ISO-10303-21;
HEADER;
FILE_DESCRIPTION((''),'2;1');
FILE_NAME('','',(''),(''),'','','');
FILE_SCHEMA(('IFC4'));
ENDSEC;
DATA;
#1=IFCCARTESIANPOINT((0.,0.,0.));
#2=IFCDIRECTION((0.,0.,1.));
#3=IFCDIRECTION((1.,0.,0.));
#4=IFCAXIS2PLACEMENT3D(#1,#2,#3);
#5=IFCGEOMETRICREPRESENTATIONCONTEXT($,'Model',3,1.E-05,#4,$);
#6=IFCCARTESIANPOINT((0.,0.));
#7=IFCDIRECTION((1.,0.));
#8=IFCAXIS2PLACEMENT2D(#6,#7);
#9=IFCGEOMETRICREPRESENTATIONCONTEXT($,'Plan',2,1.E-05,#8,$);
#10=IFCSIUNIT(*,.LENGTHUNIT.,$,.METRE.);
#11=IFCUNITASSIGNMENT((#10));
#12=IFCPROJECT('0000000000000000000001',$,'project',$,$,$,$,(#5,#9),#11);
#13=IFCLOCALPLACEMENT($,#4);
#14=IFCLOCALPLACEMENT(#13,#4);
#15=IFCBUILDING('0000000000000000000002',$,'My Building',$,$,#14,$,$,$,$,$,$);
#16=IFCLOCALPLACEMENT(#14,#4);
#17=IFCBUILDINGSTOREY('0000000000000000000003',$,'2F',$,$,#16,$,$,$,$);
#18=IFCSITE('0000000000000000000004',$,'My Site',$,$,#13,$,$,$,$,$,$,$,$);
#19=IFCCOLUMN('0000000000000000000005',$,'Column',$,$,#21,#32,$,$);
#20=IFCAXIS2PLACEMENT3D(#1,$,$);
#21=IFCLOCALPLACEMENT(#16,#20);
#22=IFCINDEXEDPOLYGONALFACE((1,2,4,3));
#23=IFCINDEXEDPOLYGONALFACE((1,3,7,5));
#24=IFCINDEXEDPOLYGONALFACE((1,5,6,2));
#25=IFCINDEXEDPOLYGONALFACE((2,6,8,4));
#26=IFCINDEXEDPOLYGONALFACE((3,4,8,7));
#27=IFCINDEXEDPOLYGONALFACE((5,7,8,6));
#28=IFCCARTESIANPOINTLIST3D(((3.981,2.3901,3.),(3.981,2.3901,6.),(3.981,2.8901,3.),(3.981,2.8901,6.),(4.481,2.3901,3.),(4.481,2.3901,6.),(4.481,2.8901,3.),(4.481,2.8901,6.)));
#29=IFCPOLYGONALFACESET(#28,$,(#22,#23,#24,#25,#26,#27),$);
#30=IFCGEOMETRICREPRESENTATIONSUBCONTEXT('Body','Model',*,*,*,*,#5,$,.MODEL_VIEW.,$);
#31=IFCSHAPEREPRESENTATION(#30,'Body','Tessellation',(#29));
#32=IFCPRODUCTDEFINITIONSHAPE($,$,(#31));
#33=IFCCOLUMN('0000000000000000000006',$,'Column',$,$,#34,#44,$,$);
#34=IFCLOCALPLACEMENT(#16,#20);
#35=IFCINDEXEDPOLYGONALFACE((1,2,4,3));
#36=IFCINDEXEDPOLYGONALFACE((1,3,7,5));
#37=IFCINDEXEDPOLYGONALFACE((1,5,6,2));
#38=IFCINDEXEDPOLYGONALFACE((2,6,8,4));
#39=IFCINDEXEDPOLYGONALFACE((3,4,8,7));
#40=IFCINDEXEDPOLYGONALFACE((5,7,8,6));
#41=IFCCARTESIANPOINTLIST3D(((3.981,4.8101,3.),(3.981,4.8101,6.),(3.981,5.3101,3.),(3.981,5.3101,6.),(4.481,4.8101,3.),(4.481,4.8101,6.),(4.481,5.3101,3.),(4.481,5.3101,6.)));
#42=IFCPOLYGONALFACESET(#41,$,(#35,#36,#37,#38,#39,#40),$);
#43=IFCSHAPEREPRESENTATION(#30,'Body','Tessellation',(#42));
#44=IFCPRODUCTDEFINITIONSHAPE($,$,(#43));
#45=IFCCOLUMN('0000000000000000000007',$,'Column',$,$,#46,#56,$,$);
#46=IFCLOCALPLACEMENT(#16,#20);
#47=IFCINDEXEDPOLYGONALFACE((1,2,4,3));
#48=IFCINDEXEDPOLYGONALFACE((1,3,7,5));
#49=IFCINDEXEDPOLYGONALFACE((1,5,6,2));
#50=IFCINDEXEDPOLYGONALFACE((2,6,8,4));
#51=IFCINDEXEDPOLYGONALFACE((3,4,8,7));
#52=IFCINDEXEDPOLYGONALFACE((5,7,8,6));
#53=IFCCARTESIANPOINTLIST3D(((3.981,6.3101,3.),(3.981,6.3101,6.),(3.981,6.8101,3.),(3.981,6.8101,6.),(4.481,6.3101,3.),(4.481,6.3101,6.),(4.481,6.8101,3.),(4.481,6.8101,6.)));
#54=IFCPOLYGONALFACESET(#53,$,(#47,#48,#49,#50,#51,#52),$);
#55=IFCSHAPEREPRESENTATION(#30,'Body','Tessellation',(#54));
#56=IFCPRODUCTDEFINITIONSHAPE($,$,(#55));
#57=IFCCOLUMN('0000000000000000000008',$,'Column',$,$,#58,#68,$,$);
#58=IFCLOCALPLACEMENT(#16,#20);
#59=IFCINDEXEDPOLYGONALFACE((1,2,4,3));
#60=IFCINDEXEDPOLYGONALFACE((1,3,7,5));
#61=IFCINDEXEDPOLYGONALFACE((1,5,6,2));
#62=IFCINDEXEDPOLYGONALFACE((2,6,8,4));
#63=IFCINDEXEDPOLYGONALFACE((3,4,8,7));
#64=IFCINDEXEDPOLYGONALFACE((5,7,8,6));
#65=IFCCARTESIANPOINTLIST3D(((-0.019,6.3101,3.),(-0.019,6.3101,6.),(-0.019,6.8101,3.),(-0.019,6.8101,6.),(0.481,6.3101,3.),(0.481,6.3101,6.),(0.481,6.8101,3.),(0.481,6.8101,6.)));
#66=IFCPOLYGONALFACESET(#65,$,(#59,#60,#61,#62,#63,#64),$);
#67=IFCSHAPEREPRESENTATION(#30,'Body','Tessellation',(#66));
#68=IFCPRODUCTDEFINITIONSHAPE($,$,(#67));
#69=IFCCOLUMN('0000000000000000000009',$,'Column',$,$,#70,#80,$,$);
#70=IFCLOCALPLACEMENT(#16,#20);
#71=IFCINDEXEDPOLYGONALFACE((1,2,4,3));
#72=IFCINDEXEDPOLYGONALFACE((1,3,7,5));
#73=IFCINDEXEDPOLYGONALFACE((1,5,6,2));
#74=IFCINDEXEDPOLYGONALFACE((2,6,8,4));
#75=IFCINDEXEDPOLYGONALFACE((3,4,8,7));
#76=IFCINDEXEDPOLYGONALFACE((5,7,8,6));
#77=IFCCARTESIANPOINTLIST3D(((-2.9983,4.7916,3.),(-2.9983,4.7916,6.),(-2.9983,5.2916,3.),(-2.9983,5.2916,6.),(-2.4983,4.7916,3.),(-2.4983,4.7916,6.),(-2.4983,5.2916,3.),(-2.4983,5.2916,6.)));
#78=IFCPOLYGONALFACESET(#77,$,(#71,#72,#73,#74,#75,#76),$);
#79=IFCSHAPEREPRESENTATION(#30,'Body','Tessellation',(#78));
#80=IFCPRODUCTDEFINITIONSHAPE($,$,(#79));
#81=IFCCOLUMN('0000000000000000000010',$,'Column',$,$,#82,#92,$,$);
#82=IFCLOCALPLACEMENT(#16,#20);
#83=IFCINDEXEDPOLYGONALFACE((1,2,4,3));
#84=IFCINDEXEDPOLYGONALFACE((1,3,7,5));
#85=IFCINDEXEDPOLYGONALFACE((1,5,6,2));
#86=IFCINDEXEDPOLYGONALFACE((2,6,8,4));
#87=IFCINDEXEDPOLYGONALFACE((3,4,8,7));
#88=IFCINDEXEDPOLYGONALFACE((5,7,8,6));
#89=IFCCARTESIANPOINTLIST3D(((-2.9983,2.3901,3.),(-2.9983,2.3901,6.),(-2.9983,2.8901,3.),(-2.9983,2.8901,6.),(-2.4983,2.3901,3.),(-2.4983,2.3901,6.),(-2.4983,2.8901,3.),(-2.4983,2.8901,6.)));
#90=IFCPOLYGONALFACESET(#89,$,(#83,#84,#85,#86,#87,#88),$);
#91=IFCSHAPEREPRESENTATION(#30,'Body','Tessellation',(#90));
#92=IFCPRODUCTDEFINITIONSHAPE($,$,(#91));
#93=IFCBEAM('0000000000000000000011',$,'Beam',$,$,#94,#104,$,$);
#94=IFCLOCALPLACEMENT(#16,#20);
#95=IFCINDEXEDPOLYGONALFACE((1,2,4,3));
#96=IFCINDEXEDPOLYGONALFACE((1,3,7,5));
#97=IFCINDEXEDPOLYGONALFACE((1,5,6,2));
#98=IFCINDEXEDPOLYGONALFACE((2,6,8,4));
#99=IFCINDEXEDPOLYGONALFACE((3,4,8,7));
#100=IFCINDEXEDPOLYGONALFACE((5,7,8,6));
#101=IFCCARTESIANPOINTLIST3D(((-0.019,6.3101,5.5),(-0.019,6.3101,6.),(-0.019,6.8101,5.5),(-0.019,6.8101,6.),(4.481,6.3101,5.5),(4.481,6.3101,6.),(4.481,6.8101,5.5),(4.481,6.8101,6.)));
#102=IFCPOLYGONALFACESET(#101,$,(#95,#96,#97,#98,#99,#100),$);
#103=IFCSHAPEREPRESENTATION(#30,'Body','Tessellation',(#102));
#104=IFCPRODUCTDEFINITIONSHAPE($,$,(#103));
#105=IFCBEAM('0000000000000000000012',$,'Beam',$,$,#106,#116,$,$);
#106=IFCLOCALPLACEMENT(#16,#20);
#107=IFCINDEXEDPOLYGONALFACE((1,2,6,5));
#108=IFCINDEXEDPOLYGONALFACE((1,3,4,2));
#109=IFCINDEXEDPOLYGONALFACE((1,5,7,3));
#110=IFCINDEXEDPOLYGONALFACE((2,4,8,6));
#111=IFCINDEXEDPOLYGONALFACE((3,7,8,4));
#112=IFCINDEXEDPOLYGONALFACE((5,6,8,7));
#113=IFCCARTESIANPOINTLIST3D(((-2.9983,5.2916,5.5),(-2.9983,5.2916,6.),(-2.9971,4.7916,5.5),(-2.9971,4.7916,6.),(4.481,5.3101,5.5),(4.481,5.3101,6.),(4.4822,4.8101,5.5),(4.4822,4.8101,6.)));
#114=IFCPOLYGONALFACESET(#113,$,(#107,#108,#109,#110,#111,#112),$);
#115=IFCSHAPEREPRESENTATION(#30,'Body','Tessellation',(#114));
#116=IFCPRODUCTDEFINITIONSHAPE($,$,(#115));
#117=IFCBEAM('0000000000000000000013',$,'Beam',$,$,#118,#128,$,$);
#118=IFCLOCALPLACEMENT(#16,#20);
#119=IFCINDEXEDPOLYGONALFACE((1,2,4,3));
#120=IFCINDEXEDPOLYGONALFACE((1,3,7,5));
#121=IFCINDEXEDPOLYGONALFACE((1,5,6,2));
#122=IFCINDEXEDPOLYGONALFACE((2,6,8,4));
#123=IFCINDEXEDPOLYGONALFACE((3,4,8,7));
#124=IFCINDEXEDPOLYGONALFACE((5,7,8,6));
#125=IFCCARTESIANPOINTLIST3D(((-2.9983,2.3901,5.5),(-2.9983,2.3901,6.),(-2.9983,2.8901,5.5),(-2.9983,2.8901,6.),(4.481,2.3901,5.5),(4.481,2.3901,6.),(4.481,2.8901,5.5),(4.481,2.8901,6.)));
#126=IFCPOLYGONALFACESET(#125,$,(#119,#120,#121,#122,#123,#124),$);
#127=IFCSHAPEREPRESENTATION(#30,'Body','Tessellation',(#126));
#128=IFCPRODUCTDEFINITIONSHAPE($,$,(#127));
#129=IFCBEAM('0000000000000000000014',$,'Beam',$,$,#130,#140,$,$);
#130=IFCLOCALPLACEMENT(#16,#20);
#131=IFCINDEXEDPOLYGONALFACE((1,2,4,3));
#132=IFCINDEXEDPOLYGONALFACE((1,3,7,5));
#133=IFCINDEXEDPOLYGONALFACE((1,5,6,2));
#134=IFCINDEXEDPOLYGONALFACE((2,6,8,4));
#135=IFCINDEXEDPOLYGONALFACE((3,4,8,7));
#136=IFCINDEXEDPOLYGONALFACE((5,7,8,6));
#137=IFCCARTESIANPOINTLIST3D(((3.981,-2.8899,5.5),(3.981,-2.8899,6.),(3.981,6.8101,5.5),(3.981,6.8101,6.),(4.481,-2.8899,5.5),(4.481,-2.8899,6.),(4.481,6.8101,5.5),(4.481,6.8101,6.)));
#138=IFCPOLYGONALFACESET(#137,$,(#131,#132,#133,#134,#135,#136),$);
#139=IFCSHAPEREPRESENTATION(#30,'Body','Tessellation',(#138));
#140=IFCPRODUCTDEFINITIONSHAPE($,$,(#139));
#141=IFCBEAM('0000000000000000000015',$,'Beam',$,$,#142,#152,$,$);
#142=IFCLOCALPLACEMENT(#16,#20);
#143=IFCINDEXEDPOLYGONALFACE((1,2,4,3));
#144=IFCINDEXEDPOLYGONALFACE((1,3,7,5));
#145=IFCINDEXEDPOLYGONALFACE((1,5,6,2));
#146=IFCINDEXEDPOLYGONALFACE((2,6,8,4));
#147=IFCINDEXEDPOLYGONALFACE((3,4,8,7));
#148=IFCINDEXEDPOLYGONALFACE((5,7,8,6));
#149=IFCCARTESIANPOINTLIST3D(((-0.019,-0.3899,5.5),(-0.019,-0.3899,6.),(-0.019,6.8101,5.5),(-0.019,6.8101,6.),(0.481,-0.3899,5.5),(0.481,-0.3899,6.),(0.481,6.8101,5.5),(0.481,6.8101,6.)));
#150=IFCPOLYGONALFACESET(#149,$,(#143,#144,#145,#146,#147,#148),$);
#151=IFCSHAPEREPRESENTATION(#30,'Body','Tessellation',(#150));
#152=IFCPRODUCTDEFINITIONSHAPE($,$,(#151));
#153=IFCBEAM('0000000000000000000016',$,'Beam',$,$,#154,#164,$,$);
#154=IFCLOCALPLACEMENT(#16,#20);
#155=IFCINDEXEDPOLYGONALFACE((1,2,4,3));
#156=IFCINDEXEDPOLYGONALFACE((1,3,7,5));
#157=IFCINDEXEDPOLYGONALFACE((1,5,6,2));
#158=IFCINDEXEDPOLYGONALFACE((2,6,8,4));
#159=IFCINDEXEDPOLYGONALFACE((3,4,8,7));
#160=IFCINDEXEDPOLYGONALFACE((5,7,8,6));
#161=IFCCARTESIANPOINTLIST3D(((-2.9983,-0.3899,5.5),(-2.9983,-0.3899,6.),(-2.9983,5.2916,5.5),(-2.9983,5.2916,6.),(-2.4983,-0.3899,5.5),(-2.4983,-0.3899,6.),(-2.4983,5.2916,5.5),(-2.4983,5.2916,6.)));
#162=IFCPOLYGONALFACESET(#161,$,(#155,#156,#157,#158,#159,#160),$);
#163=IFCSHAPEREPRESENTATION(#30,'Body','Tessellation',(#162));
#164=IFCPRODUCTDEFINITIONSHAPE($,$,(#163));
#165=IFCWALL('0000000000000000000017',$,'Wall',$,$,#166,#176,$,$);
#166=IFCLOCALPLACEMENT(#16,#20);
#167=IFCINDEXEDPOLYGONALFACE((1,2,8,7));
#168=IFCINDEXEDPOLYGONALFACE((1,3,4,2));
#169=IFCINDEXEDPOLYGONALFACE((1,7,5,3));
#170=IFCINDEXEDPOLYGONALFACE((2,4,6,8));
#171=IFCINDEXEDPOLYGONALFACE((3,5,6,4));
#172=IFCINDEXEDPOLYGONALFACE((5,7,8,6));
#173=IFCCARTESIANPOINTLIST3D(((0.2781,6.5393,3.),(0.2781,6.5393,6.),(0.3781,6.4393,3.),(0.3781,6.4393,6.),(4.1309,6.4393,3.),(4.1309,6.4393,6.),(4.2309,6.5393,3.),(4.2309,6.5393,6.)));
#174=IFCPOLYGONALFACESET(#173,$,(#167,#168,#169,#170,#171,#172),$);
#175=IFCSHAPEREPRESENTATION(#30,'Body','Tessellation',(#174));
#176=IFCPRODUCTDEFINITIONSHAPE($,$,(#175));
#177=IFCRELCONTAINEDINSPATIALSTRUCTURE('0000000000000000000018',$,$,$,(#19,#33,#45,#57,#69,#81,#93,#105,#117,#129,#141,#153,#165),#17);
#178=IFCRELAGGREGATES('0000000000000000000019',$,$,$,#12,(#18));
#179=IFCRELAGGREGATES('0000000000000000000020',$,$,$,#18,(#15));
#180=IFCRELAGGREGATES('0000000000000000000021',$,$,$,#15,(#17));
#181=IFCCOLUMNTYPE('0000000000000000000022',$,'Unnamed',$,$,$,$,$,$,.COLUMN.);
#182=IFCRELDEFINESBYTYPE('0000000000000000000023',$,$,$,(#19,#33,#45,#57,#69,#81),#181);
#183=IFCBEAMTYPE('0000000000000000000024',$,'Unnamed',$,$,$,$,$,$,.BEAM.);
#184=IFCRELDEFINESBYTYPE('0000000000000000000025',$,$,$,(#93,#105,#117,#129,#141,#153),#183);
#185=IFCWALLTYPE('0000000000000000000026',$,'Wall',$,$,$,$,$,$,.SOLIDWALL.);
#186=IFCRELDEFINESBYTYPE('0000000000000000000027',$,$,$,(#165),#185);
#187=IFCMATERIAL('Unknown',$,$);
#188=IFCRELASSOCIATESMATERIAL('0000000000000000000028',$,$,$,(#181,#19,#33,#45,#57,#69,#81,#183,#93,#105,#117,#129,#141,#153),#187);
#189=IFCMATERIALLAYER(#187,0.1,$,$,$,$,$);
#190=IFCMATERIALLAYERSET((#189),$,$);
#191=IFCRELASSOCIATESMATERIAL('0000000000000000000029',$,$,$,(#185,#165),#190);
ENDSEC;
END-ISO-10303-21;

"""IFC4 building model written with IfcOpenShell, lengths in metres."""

from ifc_helpers import new_model, si_unit, frame, origin_with_axes, origin_2d_with_axis, place, context, subcontext, project, spatial, line, indexed_curve, rectangle, outline, extrude, material, layer, layer_set, layer_usage, material_profile, profile_set, profile_usage, type_object, element, save


model = new_model("IFC4")

# Units and contexts
model_context = context("Model", 3, precision=1e-05, world=origin_with_axes())
plan_context = context("Plan", 2, precision=1e-05, world=origin_2d_with_axis())
body_context_1 = subcontext(model_context, "Body", "Model", "MODEL_VIEW")
ifc_project = project(units=[si_unit("LENGTHUNIT", "METRE")], contexts=[model_context, plan_context])

# Site, building, storey
site_placement = place(None, origin_with_axes())
site = spatial("IfcSite", under=ifc_project, at=site_placement, Name="My Site")
building_placement = place(site_placement, origin_with_axes())
building = spatial("IfcBuilding", under=site, at=building_placement, Name="My Building")
storey_placement = place(building_placement, origin_with_axes())
storey = spatial("IfcBuildingStorey", under=building, at=storey_placement, Name="2F")

# Columns
ifc_material = material(Name="Unknown")
ifc_material_profile_1 = material_profile(ifc_material, rectangle(XDim=0.5, YDim=0.5))
ifc_profile_set_1 = profile_set([ifc_material_profile_1])
ifc_profile_usage_1 = profile_usage(ifc_profile_set_1, cardinal=7)
column_type = type_object("IfcColumnType", Name="Unnamed", PredefinedType="COLUMN", material=ifc_profile_set_1)
column_1_placement = place(storey_placement, frame((4.481, 2.8901, 3.0), z_axis=(0.0, 0.0, 1.0), x_axis=(1.0, 0.0, 0.0)))
element("IfcColumn", 1, at=column_1_placement, inside=storey, type_object=column_type, material=ifc_profile_usage_1, Name="Column", context=body_context_1, shape_type="SweptSolid", body=[
    extrude(rectangle(XDim=0.5, YDim=0.5), frame((-0.25, -0.25, 0.0), z_axis=(0.0, 0.0, 1.0), x_axis=(1.0, 0.0, 0.0)), (0.0, 0.0, 1.0), 3.0),
])
ifc_profile_usage_2 = profile_usage(ifc_profile_set_1, cardinal=7)
column_2_placement = place(storey_placement, frame((4.481, 5.3101, 3.0), z_axis=(0.0, 0.0, 1.0), x_axis=(1.0, 0.0, 0.0)))
element("IfcColumn", 2, at=column_2_placement, inside=storey, type_object=column_type, material=ifc_profile_usage_2, Name="Column", context=body_context_1, shape_type="SweptSolid", body=[
    extrude(rectangle(XDim=0.5, YDim=0.5), frame((-0.25, -0.25, 0.0), z_axis=(0.0, 0.0, 1.0), x_axis=(1.0, 0.0, 0.0)), (0.0, 0.0, 1.0), 3.0),
])
ifc_profile_usage_3 = profile_usage(ifc_profile_set_1, cardinal=7)
column_3_placement = place(storey_placement, frame((4.481, 6.8101, 3.0), z_axis=(0.0, 0.0, 1.0), x_axis=(1.0, 0.0, 0.0)))
element("IfcColumn", 3, at=column_3_placement, inside=storey, type_object=column_type, material=ifc_profile_usage_3, Name="Column", context=body_context_1, shape_type="SweptSolid", body=[
    extrude(rectangle(XDim=0.5, YDim=0.5), frame((-0.25, -0.25, 0.0), z_axis=(0.0, 0.0, 1.0), x_axis=(1.0, 0.0, 0.0)), (0.0, 0.0, 1.0), 3.0),
])
ifc_profile_usage_4 = profile_usage(ifc_profile_set_1, cardinal=7)
column_4_placement = place(storey_placement, frame((0.481, 6.8101, 3.0), z_axis=(0.0, 0.0, 1.0), x_axis=(1.0, 0.0, 0.0)))
element("IfcColumn", 4, at=column_4_placement, inside=storey, type_object=column_type, material=ifc_profile_usage_4, Name="Column", context=body_context_1, shape_type="SweptSolid", body=[
    extrude(rectangle(XDim=0.5, YDim=0.5), frame((-0.25, -0.25, 0.0), z_axis=(0.0, 0.0, 1.0), x_axis=(1.0, 0.0, 0.0)), (0.0, 0.0, 1.0), 3.0),
])
ifc_profile_usage_5 = profile_usage(ifc_profile_set_1, cardinal=7)
column_5_placement = place(storey_placement, frame((-2.4983, 5.2916, 3.0), z_axis=(0.0, 0.0, 1.0), x_axis=(1.0, 0.0, 0.0)))
element("IfcColumn", 5, at=column_5_placement, inside=storey, type_object=column_type, material=ifc_profile_usage_5, Name="Column", context=body_context_1, shape_type="SweptSolid", body=[
    extrude(rectangle(XDim=0.5, YDim=0.5), frame((-0.25, -0.25, 0.0), z_axis=(0.0, 0.0, 1.0), x_axis=(1.0, 0.0, 0.0)), (0.0, 0.0, 1.0), 3.0),
])
ifc_profile_usage_6 = profile_usage(ifc_profile_set_1, cardinal=7)
column_6_placement = place(storey_placement, frame((-2.4983, 2.8901, 3.0), z_axis=(0.0, 0.0, 1.0), x_axis=(1.0, 0.0, 0.0)))
element("IfcColumn", 6, at=column_6_placement, inside=storey, type_object=column_type, material=ifc_profile_usage_6, Name="Column", context=body_context_1, shape_type="SweptSolid", body=[
    extrude(rectangle(XDim=0.5, YDim=0.5), frame((-0.25, -0.25, 0.0), z_axis=(0.0, 0.0, 1.0), x_axis=(1.0, 0.0, 0.0)), (0.0, 0.0, 1.0), 3.0),
])

# Beams
ifc_material_profile_2 = material_profile(ifc_material, rectangle(XDim=0.5, YDim=0.5))
ifc_profile_set_2 = profile_set([ifc_material_profile_2])
ifc_profile_usage_7 = profile_usage(ifc_profile_set_2, cardinal=7)
beam_type = type_object("IfcBeamType", Name="Unnamed", PredefinedType="BEAM", material=ifc_profile_set_2)
beam_1_placement = place(storey_placement, frame((-0.019, 6.8101, 6.0), z_axis=(1.0, -0.000001, 0.000001), x_axis=(0.000001, 1.0, 0.0)))
element("IfcBeam", 7, at=beam_1_placement, inside=storey, type_object=beam_type, material=ifc_profile_usage_7, Name="Beam", context=body_context_1, shape_type="SweptSolid", body=[
    extrude(rectangle(XDim=0.5, YDim=0.5), frame((-0.25, -0.25, 0.0), z_axis=(0.0, 0.0, 1.0), x_axis=(1.0, 0.0, 0.0)), (0.0, 0.0, 1.0), 4.5),
])
ifc_profile_usage_8 = profile_usage(ifc_profile_set_2, cardinal=7)
beam_2_placement = place(storey_placement, frame((-2.9983, 5.2916, 6.0), z_axis=(0.999997, 0.002473, 0.0), x_axis=(-0.002473, 0.999997, 0.0)))
element("IfcBeam", 8, at=beam_2_placement, inside=storey, type_object=beam_type, material=ifc_profile_usage_8, Name="Beam", context=body_context_1, shape_type="SweptSolid", body=[
    extrude(rectangle(XDim=0.5, YDim=0.5), frame((-0.25, -0.25, 0.0), z_axis=(0.0, 0.0, 1.0), x_axis=(1.0, 0.0, 0.0)), (0.0, 0.0, 1.0), 7.4793),
])
ifc_profile_usage_9 = profile_usage(ifc_profile_set_2, cardinal=7)
beam_3_placement = place(storey_placement, frame((-2.9983, 2.8901, 6.0), z_axis=(1.0, 0.0, 0.0), x_axis=(0.0, 1.0, 0.0)))
element("IfcBeam", 9, at=beam_3_placement, inside=storey, type_object=beam_type, material=ifc_profile_usage_9, Name="Beam", context=body_context_1, shape_type="SweptSolid", body=[
    extrude(rectangle(XDim=0.5, YDim=0.5), frame((-0.25, -0.25, 0.0), z_axis=(0.0, 0.0, 1.0), x_axis=(1.0, 0.0, 0.0)), (0.0, 0.0, 1.0), 7.4793),
])
ifc_profile_usage_10 = profile_usage(ifc_profile_set_2, cardinal=7)
beam_4_placement = place(storey_placement, frame((4.481, 6.8101, 6.0), z_axis=(0.0, -1.0, 0.0), x_axis=(1.0, 0.0, 0.0)))
element("IfcBeam", 10, at=beam_4_placement, inside=storey, type_object=beam_type, material=ifc_profile_usage_10, Name="Beam", context=body_context_1, shape_type="SweptSolid", body=[
    extrude(rectangle(XDim=0.5, YDim=0.5), frame((-0.25, -0.25, 0.0), z_axis=(0.0, 0.0, 1.0), x_axis=(1.0, 0.0, 0.0)), (0.0, 0.0, 1.0), 9.7),
])
ifc_profile_usage_11 = profile_usage(ifc_profile_set_2, cardinal=7)
beam_5_placement = place(storey_placement, frame((0.481, 6.8101, 6.0), z_axis=(0.0, -1.0, 0.0), x_axis=(1.0, 0.0, 0.0)))
element("IfcBeam", 11, at=beam_5_placement, inside=storey, type_object=beam_type, material=ifc_profile_usage_11, Name="Beam", context=body_context_1, shape_type="SweptSolid", body=[
    extrude(rectangle(XDim=0.5, YDim=0.5), frame((-0.25, -0.25, 0.0), z_axis=(0.0, 0.0, 1.0), x_axis=(1.0, 0.0, 0.0)), (0.0, 0.0, 1.0), 7.2),
])
ifc_profile_usage_12 = profile_usage(ifc_profile_set_2, cardinal=9)
beam_6_placement = place(storey_placement, frame((-2.9983, 5.2916, 6.0), z_axis=(0.0, -1.0, 0.0), x_axis=(1.0, 0.0, 0.0)))
element("IfcBeam", 12, at=beam_6_placement, inside=storey, type_object=beam_type, material=ifc_profile_usage_12, Name="Beam", context=body_context_1, shape_type="SweptSolid", body=[
    extrude(rectangle(XDim=0.5, YDim=0.5), frame((0.25, -0.25, 0.0), z_axis=(0.0, 0.0, 1.0), x_axis=(1.0, 0.0, 0.0)), (0.0, 0.0, 1.0), 5.6815),
])

# Wall
ifc_layer = layer(ifc_material, 0.1)
ifc_layer_set = layer_set([ifc_layer])
ifc_layer_usage_1 = layer_usage(ifc_layer_set, "AXIS2", "POSITIVE", 0.0)
wall_type = type_object("IfcWallType", Name="Wall", PredefinedType="SOLIDWALL", material=ifc_layer_set)
wall_1_placement = place(storey_placement, frame((4.2309, 6.5393, 3.0), z_axis=(0.0, 0.0, 1.0), x_axis=(-1.0, 0.0, 0.0)))
element("IfcWall", 13, at=wall_1_placement, inside=storey, type_object=wall_type, material=ifc_layer_usage_1, Name="Wall", context=body_context_1, shape_type="SweptSolid", body=[
    extrude(outline(indexed_curve([(0.0, 0.0), (0.1, 0.1), (3.8528, 0.1), (3.9528, 0.0)], segments=[line(1, 2, 3, 4, 1)])), origin_with_axes(), (0.0, 0.0, 1.0), 3.0),
])

save(model, "model.ifc")
